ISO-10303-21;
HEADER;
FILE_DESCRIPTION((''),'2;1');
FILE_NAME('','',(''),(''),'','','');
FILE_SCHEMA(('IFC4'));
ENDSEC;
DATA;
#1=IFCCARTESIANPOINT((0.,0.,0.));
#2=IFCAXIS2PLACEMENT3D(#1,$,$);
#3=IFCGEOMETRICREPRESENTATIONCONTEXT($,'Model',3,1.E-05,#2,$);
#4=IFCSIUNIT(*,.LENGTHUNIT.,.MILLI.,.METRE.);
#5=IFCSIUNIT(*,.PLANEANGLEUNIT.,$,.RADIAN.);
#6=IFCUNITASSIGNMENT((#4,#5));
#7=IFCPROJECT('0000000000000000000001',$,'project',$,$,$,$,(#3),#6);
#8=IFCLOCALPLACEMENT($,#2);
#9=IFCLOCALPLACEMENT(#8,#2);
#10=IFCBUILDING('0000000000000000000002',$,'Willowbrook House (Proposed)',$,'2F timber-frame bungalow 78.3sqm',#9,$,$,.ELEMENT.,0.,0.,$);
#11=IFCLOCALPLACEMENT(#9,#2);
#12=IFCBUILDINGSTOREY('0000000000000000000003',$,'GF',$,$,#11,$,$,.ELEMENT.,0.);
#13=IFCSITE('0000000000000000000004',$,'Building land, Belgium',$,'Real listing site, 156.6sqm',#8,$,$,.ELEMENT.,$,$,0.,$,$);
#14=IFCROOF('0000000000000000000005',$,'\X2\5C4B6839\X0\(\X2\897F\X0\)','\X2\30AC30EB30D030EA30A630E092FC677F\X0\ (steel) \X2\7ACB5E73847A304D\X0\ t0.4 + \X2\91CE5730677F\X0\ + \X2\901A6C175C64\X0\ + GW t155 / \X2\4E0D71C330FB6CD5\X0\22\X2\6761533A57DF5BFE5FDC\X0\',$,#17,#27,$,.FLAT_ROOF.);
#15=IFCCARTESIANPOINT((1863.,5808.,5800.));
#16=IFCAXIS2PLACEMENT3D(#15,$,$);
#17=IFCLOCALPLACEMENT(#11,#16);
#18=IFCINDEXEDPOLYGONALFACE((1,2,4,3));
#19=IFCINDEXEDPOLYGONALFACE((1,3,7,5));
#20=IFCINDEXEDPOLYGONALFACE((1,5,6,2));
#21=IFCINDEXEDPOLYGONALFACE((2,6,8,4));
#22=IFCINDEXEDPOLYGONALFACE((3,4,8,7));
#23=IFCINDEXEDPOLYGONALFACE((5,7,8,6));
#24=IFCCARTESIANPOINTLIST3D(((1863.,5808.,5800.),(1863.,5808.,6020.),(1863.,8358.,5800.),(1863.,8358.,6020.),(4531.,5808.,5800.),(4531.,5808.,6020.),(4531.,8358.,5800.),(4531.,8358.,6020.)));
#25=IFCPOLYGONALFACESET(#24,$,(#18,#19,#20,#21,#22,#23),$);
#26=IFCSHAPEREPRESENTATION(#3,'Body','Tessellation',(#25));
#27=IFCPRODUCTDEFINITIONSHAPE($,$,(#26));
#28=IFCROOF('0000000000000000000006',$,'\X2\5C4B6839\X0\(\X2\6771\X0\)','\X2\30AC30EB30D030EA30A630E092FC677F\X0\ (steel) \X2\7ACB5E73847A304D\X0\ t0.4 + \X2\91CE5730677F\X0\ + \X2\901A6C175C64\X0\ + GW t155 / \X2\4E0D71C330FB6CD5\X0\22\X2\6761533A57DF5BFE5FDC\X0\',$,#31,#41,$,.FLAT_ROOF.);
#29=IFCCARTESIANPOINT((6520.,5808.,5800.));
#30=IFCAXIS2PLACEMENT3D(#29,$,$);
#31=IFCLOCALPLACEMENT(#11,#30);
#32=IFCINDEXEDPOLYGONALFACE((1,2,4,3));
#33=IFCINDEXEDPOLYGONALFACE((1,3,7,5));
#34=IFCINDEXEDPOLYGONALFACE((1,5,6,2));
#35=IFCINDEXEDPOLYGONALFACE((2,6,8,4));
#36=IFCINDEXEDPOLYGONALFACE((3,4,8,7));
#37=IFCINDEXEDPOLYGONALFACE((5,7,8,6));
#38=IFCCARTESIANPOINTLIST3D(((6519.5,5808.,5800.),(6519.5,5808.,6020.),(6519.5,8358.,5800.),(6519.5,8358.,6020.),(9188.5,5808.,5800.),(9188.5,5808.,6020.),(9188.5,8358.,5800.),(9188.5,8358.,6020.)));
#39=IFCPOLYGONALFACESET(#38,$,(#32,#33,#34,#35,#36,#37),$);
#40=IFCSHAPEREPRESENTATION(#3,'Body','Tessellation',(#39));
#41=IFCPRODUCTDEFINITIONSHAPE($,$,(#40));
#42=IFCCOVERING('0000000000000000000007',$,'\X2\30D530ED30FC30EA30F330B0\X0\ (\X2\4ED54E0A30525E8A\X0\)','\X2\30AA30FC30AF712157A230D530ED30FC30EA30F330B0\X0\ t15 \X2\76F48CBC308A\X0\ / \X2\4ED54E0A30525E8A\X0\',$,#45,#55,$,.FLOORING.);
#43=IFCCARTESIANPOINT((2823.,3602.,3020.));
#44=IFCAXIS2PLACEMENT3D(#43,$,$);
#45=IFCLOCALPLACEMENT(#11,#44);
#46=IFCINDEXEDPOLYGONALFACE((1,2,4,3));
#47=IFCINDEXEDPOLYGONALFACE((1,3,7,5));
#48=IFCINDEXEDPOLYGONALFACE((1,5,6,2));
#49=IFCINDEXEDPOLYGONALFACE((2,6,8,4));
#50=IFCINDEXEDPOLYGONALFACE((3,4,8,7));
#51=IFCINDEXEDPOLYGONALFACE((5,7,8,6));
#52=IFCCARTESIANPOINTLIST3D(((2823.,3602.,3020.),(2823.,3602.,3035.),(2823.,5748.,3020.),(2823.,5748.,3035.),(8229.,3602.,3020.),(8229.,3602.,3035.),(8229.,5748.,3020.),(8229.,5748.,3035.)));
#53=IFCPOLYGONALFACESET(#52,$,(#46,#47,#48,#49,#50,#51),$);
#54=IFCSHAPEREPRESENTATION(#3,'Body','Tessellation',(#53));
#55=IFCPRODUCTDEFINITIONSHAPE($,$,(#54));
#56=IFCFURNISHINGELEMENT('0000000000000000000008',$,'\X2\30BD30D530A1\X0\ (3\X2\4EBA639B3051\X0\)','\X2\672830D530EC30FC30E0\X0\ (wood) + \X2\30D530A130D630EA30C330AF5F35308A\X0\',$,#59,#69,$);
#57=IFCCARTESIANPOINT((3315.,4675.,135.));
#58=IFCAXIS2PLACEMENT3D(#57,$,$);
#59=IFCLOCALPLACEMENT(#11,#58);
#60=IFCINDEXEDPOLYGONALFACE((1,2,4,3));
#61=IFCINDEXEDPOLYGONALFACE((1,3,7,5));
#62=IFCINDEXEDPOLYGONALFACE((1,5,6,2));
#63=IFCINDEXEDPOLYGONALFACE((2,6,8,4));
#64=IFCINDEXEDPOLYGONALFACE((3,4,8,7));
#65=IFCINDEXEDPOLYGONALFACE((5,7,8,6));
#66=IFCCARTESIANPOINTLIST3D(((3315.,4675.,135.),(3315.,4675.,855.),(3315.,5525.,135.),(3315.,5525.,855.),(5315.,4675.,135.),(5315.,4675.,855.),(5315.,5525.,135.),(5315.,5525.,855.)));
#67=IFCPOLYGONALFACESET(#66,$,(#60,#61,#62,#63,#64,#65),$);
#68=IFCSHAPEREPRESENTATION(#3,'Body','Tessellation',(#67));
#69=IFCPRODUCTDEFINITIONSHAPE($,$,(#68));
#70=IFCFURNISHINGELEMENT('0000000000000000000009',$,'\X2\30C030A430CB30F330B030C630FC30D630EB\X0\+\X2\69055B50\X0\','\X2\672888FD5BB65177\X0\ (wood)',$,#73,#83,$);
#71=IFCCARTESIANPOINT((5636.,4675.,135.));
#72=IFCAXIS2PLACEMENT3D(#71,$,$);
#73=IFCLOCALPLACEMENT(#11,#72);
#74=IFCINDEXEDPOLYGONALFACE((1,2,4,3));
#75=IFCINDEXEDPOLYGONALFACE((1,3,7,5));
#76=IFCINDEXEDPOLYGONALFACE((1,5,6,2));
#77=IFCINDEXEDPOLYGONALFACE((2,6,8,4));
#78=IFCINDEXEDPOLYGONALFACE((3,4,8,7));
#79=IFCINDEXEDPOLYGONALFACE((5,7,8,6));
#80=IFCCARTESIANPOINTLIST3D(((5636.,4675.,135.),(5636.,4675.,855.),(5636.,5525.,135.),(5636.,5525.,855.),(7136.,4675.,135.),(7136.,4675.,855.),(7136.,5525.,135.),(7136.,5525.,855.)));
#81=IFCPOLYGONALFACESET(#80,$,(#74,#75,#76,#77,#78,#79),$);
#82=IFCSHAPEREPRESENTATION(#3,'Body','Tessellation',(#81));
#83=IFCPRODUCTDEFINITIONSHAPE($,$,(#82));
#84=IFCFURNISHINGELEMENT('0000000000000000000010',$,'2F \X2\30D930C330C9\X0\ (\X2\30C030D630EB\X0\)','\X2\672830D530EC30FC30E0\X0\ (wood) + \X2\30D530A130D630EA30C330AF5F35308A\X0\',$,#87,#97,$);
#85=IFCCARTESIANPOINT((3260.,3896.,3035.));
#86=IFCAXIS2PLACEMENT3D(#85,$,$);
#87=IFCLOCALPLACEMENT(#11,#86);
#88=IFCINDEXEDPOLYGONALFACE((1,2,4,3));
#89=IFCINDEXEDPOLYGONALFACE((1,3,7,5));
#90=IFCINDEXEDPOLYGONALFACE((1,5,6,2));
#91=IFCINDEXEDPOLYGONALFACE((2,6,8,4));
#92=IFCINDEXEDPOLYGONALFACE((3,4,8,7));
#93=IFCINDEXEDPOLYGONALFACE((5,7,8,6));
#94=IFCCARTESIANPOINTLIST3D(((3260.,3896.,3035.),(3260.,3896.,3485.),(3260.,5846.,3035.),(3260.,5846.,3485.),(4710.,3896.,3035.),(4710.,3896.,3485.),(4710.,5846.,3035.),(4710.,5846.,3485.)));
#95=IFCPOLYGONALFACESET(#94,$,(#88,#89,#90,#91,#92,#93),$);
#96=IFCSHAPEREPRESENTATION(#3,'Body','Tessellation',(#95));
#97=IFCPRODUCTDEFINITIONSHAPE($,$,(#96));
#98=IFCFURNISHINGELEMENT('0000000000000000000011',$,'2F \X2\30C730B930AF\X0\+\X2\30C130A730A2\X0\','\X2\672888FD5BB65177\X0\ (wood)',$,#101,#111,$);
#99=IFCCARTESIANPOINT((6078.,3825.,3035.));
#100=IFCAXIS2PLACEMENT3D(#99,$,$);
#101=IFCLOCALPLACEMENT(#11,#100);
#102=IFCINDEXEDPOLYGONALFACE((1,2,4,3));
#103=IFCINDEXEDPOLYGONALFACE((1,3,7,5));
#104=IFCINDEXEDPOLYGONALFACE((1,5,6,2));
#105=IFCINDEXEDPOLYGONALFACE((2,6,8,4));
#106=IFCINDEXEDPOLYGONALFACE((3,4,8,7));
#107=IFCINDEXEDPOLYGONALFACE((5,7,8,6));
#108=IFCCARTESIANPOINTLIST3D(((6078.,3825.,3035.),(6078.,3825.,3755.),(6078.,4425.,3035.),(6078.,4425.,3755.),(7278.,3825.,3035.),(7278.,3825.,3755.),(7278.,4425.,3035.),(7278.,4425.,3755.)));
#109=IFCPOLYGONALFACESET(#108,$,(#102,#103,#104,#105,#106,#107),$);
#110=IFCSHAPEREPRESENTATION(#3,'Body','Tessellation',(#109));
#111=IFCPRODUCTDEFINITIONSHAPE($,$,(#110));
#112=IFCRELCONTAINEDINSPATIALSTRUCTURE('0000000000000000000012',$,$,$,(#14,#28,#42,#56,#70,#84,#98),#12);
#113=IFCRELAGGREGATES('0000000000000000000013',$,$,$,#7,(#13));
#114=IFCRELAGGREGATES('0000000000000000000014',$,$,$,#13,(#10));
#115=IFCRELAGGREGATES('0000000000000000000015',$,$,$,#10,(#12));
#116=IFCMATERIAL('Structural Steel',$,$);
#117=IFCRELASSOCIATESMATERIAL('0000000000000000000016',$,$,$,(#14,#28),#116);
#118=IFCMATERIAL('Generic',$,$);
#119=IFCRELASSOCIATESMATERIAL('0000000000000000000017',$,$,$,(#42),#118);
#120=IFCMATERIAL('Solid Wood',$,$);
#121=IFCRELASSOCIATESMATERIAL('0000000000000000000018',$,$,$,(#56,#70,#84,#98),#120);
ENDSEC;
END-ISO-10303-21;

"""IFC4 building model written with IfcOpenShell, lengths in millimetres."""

from ifc_helpers import new_model, si_unit, frame, frame_2d, origin, place, context, project, spatial, rectangle, extrude, material, element, save


model = new_model("IFC4")

# Units and contexts
model_context = context("Model", 3, precision=1e-05, world=origin())
ifc_project = project(units=[si_unit("LENGTHUNIT", "METRE", prefix="MILLI"), si_unit("PLANEANGLEUNIT", "RADIAN")], contexts=[model_context])

# Site, building, storey
site_placement = place(None, origin())
site = spatial("IfcSite", under=ifc_project, at=site_placement, Name="Building land, Belgium", ObjectType="Real listing site, 156.6sqm", CompositionType="ELEMENT", RefElevation=0.0)
building_placement = place(site_placement, origin())
building = spatial("IfcBuilding", under=site, at=building_placement, Name="Willowbrook House (Proposed)", ObjectType="2F timber-frame bungalow 78.3sqm", CompositionType="ELEMENT", ElevationOfRefHeight=0.0, ElevationOfTerrain=0.0)
storey_placement = place(building_placement, origin())
storey = spatial("IfcBuildingStorey", under=building, at=storey_placement, Name="GF", CompositionType="ELEMENT", Elevation=0.0)

# Shared definitions
ifc_material_1 = material(Name="Solid Wood")

# Roofs
ifc_material_2 = material(Name="Structural Steel")
roof_1_placement = place(storey_placement, frame((1863.0, 5808.0, 5800.0)))
element("IfcRoof", 1, at=roof_1_placement, inside=storey, material=ifc_material_2, Name="屋根(西)", Description="ガルバリウム鋼板 (steel) 立平葺き t0.4 + 野地板 + 通気層 + GW t155 / 不燃・法22条区域対応", PredefinedType="FLAT_ROOF", context=model_context, shape_type="SweptSolid", body=[
    extrude(rectangle(XDim=2668.0, YDim=2550.0, at=frame_2d((1334.0, 1275.0))), frame((1863.0, 5808.0, 5800.0)), (0.0, 0.0, 1.0), 220.0),
])
roof_2_placement = place(storey_placement, frame((6520.0, 5808.0, 5800.0)))
element("IfcRoof", 2, at=roof_2_placement, inside=storey, material=ifc_material_2, Name="屋根(東)", Description="ガルバリウム鋼板 (steel) 立平葺き t0.4 + 野地板 + 通気層 + GW t155 / 不燃・法22条区域対応", PredefinedType="FLAT_ROOF", context=model_context, shape_type="SweptSolid", body=[
    extrude(rectangle(XDim=2669.0, YDim=2550.0, at=frame_2d((1334.0, 1275.0))), frame((6520.0, 5808.0, 5800.0)), (0.0, 0.0, 1.0), 220.0),
])

# Covering
ifc_material_3 = material(Name="Generic")
covering_placement = place(storey_placement, frame((2823.0, 3602.0, 3020.0)))
element("IfcCovering", 3, at=covering_placement, inside=storey, material=ifc_material_3, Name="フローリング (仕上げ床)", Description="オーク無垢フローリング t15 直貼り / 仕上げ床", PredefinedType="FLOORING", context=model_context, shape_type="SweptSolid", body=[
    extrude(rectangle(XDim=5406.0, YDim=2146.0, at=frame_2d((2703.0, 1073.0))), frame((2823.0, 3602.0, 3020.0)), (0.0, 0.0, 1.0), 15.0),
])

# Furnishing elements
furnishing_1_placement = place(storey_placement, frame((3315.0, 4675.0, 135.0)))
element("IfcFurnishingElement", 4, at=furnishing_1_placement, inside=storey, material=ifc_material_1, Name="ソファ (3人掛け)", Description="木フレーム (wood) + ファブリック張り", context=model_context, shape_type="SweptSolid", body=[
    extrude(rectangle(XDim=2000.0, YDim=850.0, at=frame_2d((1000.0, 425.0))), frame((3315.0, 4675.0, 135.0)), (0.0, 0.0, 1.0), 720.0),
])
furnishing_2_placement = place(storey_placement, frame((5636.0, 4675.0, 135.0)))
element("IfcFurnishingElement", 5, at=furnishing_2_placement, inside=storey, material=ifc_material_1, Name="ダイニングテーブル+椅子", Description="木製家具 (wood)", context=model_context, shape_type="SweptSolid", body=[
    extrude(rectangle(XDim=1500.0, YDim=850.0, at=frame_2d((750.0, 425.0))), frame((5636.0, 4675.0, 135.0)), (0.0, 0.0, 1.0), 720.0),
])
furnishing_3_placement = place(storey_placement, frame((3260.0, 3896.0, 3035.0)))
element("IfcFurnishingElement", 6, at=furnishing_3_placement, inside=storey, material=ifc_material_1, Name="2F ベッド (ダブル)", Description="木フレーム (wood) + ファブリック張り", context=model_context, shape_type="SweptSolid", body=[
    extrude(rectangle(XDim=1450.0, YDim=1950.0, at=frame_2d((725.0, 975.0))), frame((3260.0, 3896.0, 3035.0)), (0.0, 0.0, 1.0), 450.0),
])
furnishing_4_placement = place(storey_placement, frame((6078.0, 3825.0, 3035.0)))
element("IfcFurnishingElement", 7, at=furnishing_4_placement, inside=storey, material=ifc_material_1, Name="2F デスク+チェア", Description="木製家具 (wood)", context=model_context, shape_type="SweptSolid", body=[
    extrude(rectangle(XDim=1200.0, YDim=600.0, at=frame_2d((600.0, 300.0))), frame((6078.0, 3825.0, 3035.0)), (0.0, 0.0, 1.0), 720.0),
])

save(model, "model.ifc")
